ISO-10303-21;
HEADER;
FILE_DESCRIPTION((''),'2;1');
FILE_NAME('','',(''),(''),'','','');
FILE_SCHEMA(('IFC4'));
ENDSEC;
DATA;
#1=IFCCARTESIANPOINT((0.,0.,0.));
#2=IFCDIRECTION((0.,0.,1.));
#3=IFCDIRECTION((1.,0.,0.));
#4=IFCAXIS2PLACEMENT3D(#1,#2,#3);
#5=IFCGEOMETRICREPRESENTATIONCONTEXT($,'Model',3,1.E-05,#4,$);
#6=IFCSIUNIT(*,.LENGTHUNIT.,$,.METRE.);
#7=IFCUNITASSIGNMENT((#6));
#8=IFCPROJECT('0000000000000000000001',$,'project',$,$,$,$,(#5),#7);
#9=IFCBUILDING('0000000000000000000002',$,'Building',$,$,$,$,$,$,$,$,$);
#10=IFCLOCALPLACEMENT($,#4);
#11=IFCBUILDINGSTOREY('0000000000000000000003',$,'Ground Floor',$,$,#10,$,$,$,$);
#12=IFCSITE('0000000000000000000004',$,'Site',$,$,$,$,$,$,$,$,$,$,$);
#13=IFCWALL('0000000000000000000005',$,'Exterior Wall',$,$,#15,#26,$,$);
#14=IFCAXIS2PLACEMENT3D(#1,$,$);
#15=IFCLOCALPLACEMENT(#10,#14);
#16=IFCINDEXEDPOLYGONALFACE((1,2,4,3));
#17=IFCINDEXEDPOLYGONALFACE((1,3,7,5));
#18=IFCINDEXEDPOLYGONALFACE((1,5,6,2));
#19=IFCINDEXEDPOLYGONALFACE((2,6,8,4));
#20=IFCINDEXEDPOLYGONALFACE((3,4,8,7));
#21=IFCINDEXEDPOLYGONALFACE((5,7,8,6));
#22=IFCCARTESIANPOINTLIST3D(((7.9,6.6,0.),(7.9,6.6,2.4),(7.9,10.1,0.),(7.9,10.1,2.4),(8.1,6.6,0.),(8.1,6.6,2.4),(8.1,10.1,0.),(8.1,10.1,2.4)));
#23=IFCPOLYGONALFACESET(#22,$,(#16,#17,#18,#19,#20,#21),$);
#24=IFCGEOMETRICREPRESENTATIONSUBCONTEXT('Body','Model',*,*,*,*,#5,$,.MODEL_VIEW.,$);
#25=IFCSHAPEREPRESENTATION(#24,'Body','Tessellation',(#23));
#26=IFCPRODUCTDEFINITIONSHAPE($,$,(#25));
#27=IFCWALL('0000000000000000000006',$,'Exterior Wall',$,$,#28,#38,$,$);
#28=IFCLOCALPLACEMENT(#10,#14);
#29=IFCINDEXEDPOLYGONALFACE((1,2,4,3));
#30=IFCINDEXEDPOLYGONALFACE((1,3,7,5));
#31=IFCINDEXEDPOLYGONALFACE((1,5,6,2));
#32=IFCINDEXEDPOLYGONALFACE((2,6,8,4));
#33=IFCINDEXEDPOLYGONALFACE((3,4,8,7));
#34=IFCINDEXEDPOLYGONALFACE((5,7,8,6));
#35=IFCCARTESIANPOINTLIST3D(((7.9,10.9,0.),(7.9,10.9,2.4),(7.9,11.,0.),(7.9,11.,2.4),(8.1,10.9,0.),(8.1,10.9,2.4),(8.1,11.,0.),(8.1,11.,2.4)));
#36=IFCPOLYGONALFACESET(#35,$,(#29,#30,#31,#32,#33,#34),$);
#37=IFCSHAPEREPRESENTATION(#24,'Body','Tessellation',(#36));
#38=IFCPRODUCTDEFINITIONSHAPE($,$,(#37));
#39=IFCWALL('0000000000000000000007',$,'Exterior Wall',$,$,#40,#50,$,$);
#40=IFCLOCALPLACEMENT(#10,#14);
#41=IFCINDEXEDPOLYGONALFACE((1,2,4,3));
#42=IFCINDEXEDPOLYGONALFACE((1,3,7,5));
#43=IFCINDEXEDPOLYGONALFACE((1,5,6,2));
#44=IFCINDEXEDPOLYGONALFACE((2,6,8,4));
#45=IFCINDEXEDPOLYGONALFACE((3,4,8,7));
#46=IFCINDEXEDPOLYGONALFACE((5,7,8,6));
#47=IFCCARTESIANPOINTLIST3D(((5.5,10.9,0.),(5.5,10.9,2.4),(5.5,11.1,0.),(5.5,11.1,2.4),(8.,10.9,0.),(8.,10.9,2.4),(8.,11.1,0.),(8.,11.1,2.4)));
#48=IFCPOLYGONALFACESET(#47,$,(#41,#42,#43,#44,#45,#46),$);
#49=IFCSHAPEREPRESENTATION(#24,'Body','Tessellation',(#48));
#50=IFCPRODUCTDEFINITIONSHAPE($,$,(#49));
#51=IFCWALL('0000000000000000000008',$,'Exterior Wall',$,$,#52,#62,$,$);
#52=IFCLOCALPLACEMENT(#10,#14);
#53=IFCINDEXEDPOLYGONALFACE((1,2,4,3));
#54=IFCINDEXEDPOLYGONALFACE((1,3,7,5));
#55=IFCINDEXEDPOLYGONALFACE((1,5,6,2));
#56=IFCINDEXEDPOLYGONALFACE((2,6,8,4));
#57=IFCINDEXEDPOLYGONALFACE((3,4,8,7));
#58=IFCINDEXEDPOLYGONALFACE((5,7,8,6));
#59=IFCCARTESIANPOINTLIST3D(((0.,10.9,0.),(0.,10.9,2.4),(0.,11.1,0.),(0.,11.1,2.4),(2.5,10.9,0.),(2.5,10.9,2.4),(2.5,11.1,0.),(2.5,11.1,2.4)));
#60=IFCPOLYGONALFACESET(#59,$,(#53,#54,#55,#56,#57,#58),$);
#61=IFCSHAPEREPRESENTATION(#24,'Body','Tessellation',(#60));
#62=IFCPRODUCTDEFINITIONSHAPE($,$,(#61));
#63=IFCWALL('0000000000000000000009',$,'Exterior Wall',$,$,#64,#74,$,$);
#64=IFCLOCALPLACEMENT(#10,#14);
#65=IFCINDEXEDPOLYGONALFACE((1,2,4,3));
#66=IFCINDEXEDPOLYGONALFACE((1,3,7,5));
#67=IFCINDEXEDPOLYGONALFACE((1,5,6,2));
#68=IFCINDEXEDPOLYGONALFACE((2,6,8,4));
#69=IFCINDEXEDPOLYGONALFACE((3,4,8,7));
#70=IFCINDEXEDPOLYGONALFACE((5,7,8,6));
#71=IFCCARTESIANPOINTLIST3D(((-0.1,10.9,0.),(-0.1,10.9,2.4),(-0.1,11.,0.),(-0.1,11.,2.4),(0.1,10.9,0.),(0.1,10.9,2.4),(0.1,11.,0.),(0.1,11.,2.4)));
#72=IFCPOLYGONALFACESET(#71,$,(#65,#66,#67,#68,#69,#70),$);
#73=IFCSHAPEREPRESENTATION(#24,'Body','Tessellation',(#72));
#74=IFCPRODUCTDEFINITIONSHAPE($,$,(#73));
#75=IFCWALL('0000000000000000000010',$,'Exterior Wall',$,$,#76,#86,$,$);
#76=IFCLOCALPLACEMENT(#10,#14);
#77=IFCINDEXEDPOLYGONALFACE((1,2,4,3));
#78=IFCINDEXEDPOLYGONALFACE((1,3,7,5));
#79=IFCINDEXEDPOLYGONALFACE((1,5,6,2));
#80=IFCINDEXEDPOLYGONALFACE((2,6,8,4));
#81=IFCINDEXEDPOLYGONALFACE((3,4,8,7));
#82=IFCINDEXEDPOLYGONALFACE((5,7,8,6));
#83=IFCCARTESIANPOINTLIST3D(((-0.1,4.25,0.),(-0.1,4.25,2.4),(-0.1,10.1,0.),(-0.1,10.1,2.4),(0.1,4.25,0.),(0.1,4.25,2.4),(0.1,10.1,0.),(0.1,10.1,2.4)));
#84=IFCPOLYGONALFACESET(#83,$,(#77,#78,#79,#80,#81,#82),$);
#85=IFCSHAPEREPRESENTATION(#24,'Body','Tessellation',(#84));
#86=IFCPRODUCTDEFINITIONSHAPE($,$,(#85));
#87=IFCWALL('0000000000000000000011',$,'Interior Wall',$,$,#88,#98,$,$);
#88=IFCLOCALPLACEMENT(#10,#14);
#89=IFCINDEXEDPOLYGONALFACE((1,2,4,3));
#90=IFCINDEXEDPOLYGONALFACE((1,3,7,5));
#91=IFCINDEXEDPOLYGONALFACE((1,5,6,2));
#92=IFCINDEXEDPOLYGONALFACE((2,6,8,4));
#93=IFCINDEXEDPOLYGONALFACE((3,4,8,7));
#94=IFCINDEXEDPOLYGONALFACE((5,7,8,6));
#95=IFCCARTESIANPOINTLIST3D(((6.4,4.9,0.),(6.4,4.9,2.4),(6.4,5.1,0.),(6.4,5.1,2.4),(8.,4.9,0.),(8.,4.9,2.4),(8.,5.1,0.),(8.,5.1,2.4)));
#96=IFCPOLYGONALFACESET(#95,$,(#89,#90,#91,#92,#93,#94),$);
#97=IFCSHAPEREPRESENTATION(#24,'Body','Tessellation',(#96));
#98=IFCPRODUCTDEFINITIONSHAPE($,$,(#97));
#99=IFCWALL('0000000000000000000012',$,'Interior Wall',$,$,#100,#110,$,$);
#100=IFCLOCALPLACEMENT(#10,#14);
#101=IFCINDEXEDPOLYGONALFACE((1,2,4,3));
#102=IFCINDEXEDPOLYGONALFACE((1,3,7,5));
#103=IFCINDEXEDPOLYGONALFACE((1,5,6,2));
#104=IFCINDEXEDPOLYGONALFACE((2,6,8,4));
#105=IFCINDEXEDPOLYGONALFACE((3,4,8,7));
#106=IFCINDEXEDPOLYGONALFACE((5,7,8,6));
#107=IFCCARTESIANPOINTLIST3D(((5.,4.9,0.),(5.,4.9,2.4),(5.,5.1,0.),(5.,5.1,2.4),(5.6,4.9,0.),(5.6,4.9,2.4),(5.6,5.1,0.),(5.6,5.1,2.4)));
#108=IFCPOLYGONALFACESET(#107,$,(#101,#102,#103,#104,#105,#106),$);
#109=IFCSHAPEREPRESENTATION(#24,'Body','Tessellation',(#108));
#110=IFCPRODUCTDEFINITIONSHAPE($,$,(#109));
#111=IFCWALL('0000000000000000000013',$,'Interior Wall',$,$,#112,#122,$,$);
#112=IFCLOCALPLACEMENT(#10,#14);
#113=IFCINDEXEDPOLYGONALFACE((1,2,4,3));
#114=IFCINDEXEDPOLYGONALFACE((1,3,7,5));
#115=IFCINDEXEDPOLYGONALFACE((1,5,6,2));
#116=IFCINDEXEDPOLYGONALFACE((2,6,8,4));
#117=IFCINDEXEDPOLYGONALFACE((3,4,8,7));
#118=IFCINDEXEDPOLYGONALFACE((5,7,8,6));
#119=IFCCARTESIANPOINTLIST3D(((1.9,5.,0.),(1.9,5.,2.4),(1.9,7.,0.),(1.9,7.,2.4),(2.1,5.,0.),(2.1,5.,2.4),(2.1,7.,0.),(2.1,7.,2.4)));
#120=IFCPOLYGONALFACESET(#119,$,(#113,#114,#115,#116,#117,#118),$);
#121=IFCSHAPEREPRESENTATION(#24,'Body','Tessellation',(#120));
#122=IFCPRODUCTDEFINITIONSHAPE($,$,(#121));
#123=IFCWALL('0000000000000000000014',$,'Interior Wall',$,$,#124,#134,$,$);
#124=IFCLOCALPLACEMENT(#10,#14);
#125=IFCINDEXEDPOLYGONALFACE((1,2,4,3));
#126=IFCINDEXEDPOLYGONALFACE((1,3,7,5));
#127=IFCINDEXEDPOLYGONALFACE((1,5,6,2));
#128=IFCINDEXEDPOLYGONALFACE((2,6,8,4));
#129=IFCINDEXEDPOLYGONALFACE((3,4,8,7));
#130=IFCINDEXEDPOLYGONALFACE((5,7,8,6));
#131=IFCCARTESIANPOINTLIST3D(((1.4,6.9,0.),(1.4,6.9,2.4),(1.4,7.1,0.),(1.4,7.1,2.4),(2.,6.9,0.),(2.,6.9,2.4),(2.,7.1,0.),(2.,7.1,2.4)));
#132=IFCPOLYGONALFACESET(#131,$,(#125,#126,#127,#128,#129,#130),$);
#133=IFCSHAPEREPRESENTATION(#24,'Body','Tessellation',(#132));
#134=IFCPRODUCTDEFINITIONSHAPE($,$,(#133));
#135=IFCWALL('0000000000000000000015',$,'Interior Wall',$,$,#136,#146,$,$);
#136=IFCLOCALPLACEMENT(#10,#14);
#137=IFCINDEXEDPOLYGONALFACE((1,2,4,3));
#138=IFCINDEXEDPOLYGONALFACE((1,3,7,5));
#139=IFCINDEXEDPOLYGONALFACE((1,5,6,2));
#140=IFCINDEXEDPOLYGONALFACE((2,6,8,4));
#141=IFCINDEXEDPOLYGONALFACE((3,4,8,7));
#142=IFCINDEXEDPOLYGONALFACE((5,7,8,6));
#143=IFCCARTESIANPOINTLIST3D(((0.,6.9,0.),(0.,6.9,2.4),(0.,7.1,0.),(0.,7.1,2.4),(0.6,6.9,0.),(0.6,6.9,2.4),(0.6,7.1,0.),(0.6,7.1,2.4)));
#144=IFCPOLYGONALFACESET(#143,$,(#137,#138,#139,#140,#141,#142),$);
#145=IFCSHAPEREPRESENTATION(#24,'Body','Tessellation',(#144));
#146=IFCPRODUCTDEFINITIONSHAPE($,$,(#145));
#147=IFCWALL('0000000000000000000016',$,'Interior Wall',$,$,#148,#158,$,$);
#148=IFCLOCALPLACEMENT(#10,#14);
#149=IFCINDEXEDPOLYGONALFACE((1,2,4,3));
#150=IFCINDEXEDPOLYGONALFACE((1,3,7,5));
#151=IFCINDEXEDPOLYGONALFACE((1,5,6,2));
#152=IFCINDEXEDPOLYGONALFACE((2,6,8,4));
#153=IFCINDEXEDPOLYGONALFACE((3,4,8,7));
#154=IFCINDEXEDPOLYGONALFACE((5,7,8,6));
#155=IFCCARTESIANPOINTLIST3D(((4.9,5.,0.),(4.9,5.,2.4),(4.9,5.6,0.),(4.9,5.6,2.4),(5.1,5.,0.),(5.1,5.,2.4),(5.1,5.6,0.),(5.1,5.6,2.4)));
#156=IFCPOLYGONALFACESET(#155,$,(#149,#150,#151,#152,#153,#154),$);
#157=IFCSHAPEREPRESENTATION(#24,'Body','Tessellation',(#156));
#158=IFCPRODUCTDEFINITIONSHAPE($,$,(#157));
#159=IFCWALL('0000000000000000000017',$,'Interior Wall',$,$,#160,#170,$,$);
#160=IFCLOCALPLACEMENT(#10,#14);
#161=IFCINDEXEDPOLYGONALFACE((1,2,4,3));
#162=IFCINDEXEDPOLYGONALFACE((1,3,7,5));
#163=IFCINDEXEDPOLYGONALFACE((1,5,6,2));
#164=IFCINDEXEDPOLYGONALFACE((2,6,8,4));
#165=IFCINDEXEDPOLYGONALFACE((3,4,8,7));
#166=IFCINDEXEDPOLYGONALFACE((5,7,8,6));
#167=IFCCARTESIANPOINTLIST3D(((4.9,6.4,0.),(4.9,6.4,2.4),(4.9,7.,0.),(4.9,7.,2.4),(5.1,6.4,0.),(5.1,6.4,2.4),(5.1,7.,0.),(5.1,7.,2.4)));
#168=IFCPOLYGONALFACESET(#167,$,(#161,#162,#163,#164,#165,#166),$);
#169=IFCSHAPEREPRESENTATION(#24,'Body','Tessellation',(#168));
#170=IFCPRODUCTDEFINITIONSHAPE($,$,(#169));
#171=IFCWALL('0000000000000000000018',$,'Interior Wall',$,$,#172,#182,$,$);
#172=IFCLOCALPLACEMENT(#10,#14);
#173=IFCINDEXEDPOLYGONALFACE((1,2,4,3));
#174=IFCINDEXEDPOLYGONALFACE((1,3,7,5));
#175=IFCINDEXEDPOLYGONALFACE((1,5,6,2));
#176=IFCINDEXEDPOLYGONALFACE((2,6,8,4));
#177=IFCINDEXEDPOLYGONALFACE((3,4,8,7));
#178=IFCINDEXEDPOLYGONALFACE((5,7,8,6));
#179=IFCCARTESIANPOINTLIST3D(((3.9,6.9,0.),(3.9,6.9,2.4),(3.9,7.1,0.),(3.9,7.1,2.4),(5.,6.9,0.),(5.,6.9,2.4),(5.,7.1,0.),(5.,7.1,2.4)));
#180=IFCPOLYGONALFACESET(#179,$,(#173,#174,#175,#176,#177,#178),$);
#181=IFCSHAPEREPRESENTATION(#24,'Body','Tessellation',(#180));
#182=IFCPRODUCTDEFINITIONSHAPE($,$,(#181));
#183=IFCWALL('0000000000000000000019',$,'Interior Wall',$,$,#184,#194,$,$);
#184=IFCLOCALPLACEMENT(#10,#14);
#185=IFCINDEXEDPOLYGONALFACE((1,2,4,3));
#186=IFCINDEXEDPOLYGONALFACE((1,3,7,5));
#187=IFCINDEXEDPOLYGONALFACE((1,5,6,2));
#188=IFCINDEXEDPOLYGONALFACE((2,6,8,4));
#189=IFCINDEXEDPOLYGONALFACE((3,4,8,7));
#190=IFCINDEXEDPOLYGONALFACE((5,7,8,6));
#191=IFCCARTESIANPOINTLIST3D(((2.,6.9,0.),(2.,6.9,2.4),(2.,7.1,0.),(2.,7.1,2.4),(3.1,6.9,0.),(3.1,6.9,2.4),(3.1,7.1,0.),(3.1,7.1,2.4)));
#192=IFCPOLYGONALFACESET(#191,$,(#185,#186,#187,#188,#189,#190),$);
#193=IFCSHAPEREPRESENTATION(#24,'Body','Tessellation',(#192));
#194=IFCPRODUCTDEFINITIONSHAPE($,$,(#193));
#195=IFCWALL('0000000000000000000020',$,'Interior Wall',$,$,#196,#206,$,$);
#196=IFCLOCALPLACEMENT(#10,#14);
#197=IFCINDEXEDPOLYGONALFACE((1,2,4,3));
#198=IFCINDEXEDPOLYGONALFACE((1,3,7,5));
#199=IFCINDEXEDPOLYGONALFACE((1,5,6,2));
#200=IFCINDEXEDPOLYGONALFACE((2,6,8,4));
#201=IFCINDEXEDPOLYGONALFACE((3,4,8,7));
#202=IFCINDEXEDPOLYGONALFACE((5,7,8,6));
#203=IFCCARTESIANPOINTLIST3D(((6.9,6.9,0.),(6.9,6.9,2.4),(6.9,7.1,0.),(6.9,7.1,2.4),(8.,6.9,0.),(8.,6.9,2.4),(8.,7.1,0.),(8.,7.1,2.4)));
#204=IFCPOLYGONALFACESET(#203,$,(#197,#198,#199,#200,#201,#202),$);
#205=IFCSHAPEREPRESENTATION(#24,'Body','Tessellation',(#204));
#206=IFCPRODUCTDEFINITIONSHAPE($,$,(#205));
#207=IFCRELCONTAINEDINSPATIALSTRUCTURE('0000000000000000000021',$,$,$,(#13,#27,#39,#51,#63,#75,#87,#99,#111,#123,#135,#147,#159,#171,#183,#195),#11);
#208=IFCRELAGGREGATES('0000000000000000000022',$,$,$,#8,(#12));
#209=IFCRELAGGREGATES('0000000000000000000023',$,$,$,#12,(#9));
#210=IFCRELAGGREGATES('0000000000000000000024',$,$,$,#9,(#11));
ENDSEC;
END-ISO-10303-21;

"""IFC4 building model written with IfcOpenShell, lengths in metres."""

from ifc_helpers import new_model, si_unit, frame, origin_with_axes, place, context, subcontext, project, spatial, indexed_curve, outline, extrude, element, save


model = new_model("IFC4")

# Units and contexts
model_context = context("Model", 3, precision=1e-05, world=origin_with_axes())
body_context = subcontext(model_context, "Body", "Model", "MODEL_VIEW")
ifc_project = project(units=[si_unit("LENGTHUNIT", "METRE")], contexts=[model_context])

# Site, building, storey
site = spatial("IfcSite", under=ifc_project, Name="Site")
building = spatial("IfcBuilding", under=site, Name="Building")
storey_placement = place(None, origin_with_axes())
storey = spatial("IfcBuildingStorey", under=building, at=storey_placement, Name="Ground Floor")

# Walls
wall_1_placement = place(storey_placement, frame((8.0, 6.6, 0.0), z_axis=(0.0, 0.0, 1.0), x_axis=(0.0, 1.0, 0.0)))
element("IfcWall", 1, at=wall_1_placement, inside=storey, Name="Exterior Wall", context=body_context, shape_type="SweptSolid", body=[
    extrude(outline(indexed_curve([(0.0, 0.0), (0.0, 0.2), (3.5, 0.2), (3.5, 0.0), (0.0, 0.0)], self_intersect=False)), frame((0.0, -0.1, 0.0), z_axis=(0.0, 0.0, 1.0), x_axis=(1.0, 0.0, 0.0)), (0.0, 0.0, 1.0), 2.4),
])
wall_2_placement = place(storey_placement, frame((8.0, 10.9, 0.0), z_axis=(0.0, 0.0, 1.0), x_axis=(0.0, 1.0, 0.0)))
element("IfcWall", 2, at=wall_2_placement, inside=storey, Name="Exterior Wall", context=body_context, shape_type="SweptSolid", body=[
    extrude(outline(indexed_curve([(0.0, 0.0), (0.0, 0.2), (0.1, 0.2), (0.1, 0.0), (0.0, 0.0)], self_intersect=False)), frame((0.0, -0.1, 0.0), z_axis=(0.0, 0.0, 1.0), x_axis=(1.0, 0.0, 0.0)), (0.0, 0.0, 1.0), 2.4),
])
for number, where, z_axis, x_axis, name in (
    (3, (8.0, 11.0, 0.0), (0.0, 0.0, 1.0), (-1.0, 0.0, 0.0), "Exterior Wall"),
    (4, (2.5, 11.0, 0.0), (0.0, 0.0, 1.0), (-1.0, 0.0, 0.0), "Exterior Wall"),
):
    element("IfcWall", number, at=place(storey_placement, frame(where, z_axis=z_axis, x_axis=x_axis)), inside=storey, Name=name, context=body_context, shape_type="SweptSolid", body=[
        extrude(outline(indexed_curve([(0.0, 0.0), (0.0, 0.2), (2.5, 0.2), (2.5, 0.0), (0.0, 0.0)], self_intersect=False)), frame((0.0, -0.1, 0.0), z_axis=(0.0, 0.0, 1.0), x_axis=(1.0, 0.0, 0.0)), (0.0, 0.0, 1.0), 2.4),
    ])
wall_3_placement = place(storey_placement, frame((0.0, 11.0, 0.0), z_axis=(0.0, 0.0, 1.0), x_axis=(0.0, -1.0, 0.0)))
element("IfcWall", 5, at=wall_3_placement, inside=storey, Name="Exterior Wall", context=body_context, shape_type="SweptSolid", body=[
    extrude(outline(indexed_curve([(0.0, 0.0), (0.0, 0.2), (0.1, 0.2), (0.1, 0.0), (0.0, 0.0)], self_intersect=False)), frame((0.0, -0.1, 0.0), z_axis=(0.0, 0.0, 1.0), x_axis=(1.0, 0.0, 0.0)), (0.0, 0.0, 1.0), 2.4),
])
wall_4_placement = place(storey_placement, frame((0.0, 10.1, 0.0), z_axis=(0.0, 0.0, 1.0), x_axis=(0.0, -1.0, 0.0)))
element("IfcWall", 6, at=wall_4_placement, inside=storey, Name="Exterior Wall", context=body_context, shape_type="SweptSolid", body=[
    extrude(outline(indexed_curve([(0.0, 0.0), (0.0, 0.2), (5.85, 0.2), (5.85, 0.0), (0.0, 0.0)], self_intersect=False)), frame((0.0, -0.1, 0.0), z_axis=(0.0, 0.0, 1.0), x_axis=(1.0, 0.0, 0.0)), (0.0, 0.0, 1.0), 2.4),
])
wall_5_placement = place(storey_placement, frame((8.0, 5.0, 0.0), z_axis=(0.0, 0.0, 1.0), x_axis=(-1.0, 0.0, 0.0)))
element("IfcWall", 7, at=wall_5_placement, inside=storey, Name="Interior Wall", context=body_context, shape_type="SweptSolid", body=[
    extrude(outline(indexed_curve([(0.0, 0.0), (0.0, 0.2), (1.6, 0.2), (1.6, 0.0), (0.0, 0.0)], self_intersect=False)), frame((0.0, -0.1, 0.0), z_axis=(0.0, 0.0, 1.0), x_axis=(1.0, 0.0, 0.0)), (0.0, 0.0, 1.0), 2.4),
])
wall_6_placement = place(storey_placement, frame((5.6, 5.0, 0.0), z_axis=(0.0, 0.0, 1.0), x_axis=(-1.0, 0.0, 0.0)))
element("IfcWall", 8, at=wall_6_placement, inside=storey, Name="Interior Wall", context=body_context, shape_type="SweptSolid", body=[
    extrude(outline(indexed_curve([(0.0, 0.0), (0.0, 0.2), (0.6, 0.2), (0.6, 0.0), (0.0, 0.0)], self_intersect=False)), frame((0.0, -0.1, 0.0), z_axis=(0.0, 0.0, 1.0), x_axis=(1.0, 0.0, 0.0)), (0.0, 0.0, 1.0), 2.4),
])
wall_7_placement = place(storey_placement, frame((2.0, 5.0, 0.0), z_axis=(0.0, 0.0, 1.0), x_axis=(0.0, 1.0, 0.0)))
element("IfcWall", 9, at=wall_7_placement, inside=storey, Name="Interior Wall", context=body_context, shape_type="SweptSolid", body=[
    extrude(outline(indexed_curve([(0.0, 0.0), (0.0, 0.2), (2.0, 0.2), (2.0, 0.0), (0.0, 0.0)], self_intersect=False)), frame((0.0, -0.1, 0.0), z_axis=(0.0, 0.0, 1.0), x_axis=(1.0, 0.0, 0.0)), (0.0, 0.0, 1.0), 2.4),
])
for number, where, z_axis, x_axis, name in (
    (10, (2.0, 7.0, 0.0), (0.0, 0.0, 1.0), (-1.0, 0.0, 0.0), "Interior Wall"),
    (11, (0.6, 7.0, 0.0), (0.0, 0.0, 1.0), (-1.0, 0.0, 0.0), "Interior Wall"),
):
    element("IfcWall", number, at=place(storey_placement, frame(where, z_axis=z_axis, x_axis=x_axis)), inside=storey, Name=name, context=body_context, shape_type="SweptSolid", body=[
        extrude(outline(indexed_curve([(0.0, 0.0), (0.0, 0.2), (0.6, 0.2), (0.6, 0.0), (0.0, 0.0)], self_intersect=False)), frame((0.0, -0.1, 0.0), z_axis=(0.0, 0.0, 1.0), x_axis=(1.0, 0.0, 0.0)), (0.0, 0.0, 1.0), 2.4),
    ])
for number, where, z_axis, x_axis, name in (
    (12, (5.0, 5.0, 0.0), (0.0, 0.0, 1.0), (0.0, 1.0, 0.0), "Interior Wall"),
    (13, (5.0, 6.4, 0.0), (0.0, 0.0, 1.0), (0.0, 1.0, 0.0), "Interior Wall"),
):
    element("IfcWall", number, at=place(storey_placement, frame(where, z_axis=z_axis, x_axis=x_axis)), inside=storey, Name=name, context=body_context, shape_type="SweptSolid", body=[
        extrude(outline(indexed_curve([(0.0, 0.0), (0.0, 0.2), (0.6, 0.2), (0.6, 0.0), (0.0, 0.0)], self_intersect=False)), frame((0.0, -0.1, 0.0), z_axis=(0.0, 0.0, 1.0), x_axis=(1.0, 0.0, 0.0)), (0.0, 0.0, 1.0), 2.4),
    ])
for number, where, z_axis, x_axis, name in (
    (14, (5.0, 7.0, 0.0), (0.0, 0.0, 1.0), (-1.0, 0.0, 0.0), "Interior Wall"),
    (15, (3.1, 7.0, 0.0), (0.0, 0.0, 1.0), (-1.0, 0.0, 0.0), "Interior Wall"),
):
    element("IfcWall", number, at=place(storey_placement, frame(where, z_axis=z_axis, x_axis=x_axis)), inside=storey, Name=name, context=body_context, shape_type="SweptSolid", body=[
        extrude(outline(indexed_curve([(0.0, 0.0), (0.0, 0.2), (1.1, 0.2), (1.1, 0.0), (0.0, 0.0)], self_intersect=False)), frame((0.0, -0.1, 0.0), z_axis=(0.0, 0.0, 1.0), x_axis=(1.0, 0.0, 0.0)), (0.0, 0.0, 1.0), 2.4),
    ])
for number, where, z_axis, x_axis, name in (
    (16, (8.0, 7.0, 0.0), (0.0, 0.0, 1.0), (-1.0, 0.0, 0.0), "Interior Wall"),
):
    element("IfcWall", number, at=place(storey_placement, frame(where, z_axis=z_axis, x_axis=x_axis)), inside=storey, Name=name, context=body_context, shape_type="SweptSolid", body=[
        extrude(outline(indexed_curve([(0.0, 0.0), (0.0, 0.2), (1.1, 0.2), (1.1, 0.0), (0.0, 0.0)], self_intersect=False)), frame((0.0, -0.1, 0.0), z_axis=(0.0, 0.0, 1.0), x_axis=(1.0, 0.0, 0.0)), (0.0, 0.0, 1.0), 2.4),
    ])

save(model, "model.ifc")
